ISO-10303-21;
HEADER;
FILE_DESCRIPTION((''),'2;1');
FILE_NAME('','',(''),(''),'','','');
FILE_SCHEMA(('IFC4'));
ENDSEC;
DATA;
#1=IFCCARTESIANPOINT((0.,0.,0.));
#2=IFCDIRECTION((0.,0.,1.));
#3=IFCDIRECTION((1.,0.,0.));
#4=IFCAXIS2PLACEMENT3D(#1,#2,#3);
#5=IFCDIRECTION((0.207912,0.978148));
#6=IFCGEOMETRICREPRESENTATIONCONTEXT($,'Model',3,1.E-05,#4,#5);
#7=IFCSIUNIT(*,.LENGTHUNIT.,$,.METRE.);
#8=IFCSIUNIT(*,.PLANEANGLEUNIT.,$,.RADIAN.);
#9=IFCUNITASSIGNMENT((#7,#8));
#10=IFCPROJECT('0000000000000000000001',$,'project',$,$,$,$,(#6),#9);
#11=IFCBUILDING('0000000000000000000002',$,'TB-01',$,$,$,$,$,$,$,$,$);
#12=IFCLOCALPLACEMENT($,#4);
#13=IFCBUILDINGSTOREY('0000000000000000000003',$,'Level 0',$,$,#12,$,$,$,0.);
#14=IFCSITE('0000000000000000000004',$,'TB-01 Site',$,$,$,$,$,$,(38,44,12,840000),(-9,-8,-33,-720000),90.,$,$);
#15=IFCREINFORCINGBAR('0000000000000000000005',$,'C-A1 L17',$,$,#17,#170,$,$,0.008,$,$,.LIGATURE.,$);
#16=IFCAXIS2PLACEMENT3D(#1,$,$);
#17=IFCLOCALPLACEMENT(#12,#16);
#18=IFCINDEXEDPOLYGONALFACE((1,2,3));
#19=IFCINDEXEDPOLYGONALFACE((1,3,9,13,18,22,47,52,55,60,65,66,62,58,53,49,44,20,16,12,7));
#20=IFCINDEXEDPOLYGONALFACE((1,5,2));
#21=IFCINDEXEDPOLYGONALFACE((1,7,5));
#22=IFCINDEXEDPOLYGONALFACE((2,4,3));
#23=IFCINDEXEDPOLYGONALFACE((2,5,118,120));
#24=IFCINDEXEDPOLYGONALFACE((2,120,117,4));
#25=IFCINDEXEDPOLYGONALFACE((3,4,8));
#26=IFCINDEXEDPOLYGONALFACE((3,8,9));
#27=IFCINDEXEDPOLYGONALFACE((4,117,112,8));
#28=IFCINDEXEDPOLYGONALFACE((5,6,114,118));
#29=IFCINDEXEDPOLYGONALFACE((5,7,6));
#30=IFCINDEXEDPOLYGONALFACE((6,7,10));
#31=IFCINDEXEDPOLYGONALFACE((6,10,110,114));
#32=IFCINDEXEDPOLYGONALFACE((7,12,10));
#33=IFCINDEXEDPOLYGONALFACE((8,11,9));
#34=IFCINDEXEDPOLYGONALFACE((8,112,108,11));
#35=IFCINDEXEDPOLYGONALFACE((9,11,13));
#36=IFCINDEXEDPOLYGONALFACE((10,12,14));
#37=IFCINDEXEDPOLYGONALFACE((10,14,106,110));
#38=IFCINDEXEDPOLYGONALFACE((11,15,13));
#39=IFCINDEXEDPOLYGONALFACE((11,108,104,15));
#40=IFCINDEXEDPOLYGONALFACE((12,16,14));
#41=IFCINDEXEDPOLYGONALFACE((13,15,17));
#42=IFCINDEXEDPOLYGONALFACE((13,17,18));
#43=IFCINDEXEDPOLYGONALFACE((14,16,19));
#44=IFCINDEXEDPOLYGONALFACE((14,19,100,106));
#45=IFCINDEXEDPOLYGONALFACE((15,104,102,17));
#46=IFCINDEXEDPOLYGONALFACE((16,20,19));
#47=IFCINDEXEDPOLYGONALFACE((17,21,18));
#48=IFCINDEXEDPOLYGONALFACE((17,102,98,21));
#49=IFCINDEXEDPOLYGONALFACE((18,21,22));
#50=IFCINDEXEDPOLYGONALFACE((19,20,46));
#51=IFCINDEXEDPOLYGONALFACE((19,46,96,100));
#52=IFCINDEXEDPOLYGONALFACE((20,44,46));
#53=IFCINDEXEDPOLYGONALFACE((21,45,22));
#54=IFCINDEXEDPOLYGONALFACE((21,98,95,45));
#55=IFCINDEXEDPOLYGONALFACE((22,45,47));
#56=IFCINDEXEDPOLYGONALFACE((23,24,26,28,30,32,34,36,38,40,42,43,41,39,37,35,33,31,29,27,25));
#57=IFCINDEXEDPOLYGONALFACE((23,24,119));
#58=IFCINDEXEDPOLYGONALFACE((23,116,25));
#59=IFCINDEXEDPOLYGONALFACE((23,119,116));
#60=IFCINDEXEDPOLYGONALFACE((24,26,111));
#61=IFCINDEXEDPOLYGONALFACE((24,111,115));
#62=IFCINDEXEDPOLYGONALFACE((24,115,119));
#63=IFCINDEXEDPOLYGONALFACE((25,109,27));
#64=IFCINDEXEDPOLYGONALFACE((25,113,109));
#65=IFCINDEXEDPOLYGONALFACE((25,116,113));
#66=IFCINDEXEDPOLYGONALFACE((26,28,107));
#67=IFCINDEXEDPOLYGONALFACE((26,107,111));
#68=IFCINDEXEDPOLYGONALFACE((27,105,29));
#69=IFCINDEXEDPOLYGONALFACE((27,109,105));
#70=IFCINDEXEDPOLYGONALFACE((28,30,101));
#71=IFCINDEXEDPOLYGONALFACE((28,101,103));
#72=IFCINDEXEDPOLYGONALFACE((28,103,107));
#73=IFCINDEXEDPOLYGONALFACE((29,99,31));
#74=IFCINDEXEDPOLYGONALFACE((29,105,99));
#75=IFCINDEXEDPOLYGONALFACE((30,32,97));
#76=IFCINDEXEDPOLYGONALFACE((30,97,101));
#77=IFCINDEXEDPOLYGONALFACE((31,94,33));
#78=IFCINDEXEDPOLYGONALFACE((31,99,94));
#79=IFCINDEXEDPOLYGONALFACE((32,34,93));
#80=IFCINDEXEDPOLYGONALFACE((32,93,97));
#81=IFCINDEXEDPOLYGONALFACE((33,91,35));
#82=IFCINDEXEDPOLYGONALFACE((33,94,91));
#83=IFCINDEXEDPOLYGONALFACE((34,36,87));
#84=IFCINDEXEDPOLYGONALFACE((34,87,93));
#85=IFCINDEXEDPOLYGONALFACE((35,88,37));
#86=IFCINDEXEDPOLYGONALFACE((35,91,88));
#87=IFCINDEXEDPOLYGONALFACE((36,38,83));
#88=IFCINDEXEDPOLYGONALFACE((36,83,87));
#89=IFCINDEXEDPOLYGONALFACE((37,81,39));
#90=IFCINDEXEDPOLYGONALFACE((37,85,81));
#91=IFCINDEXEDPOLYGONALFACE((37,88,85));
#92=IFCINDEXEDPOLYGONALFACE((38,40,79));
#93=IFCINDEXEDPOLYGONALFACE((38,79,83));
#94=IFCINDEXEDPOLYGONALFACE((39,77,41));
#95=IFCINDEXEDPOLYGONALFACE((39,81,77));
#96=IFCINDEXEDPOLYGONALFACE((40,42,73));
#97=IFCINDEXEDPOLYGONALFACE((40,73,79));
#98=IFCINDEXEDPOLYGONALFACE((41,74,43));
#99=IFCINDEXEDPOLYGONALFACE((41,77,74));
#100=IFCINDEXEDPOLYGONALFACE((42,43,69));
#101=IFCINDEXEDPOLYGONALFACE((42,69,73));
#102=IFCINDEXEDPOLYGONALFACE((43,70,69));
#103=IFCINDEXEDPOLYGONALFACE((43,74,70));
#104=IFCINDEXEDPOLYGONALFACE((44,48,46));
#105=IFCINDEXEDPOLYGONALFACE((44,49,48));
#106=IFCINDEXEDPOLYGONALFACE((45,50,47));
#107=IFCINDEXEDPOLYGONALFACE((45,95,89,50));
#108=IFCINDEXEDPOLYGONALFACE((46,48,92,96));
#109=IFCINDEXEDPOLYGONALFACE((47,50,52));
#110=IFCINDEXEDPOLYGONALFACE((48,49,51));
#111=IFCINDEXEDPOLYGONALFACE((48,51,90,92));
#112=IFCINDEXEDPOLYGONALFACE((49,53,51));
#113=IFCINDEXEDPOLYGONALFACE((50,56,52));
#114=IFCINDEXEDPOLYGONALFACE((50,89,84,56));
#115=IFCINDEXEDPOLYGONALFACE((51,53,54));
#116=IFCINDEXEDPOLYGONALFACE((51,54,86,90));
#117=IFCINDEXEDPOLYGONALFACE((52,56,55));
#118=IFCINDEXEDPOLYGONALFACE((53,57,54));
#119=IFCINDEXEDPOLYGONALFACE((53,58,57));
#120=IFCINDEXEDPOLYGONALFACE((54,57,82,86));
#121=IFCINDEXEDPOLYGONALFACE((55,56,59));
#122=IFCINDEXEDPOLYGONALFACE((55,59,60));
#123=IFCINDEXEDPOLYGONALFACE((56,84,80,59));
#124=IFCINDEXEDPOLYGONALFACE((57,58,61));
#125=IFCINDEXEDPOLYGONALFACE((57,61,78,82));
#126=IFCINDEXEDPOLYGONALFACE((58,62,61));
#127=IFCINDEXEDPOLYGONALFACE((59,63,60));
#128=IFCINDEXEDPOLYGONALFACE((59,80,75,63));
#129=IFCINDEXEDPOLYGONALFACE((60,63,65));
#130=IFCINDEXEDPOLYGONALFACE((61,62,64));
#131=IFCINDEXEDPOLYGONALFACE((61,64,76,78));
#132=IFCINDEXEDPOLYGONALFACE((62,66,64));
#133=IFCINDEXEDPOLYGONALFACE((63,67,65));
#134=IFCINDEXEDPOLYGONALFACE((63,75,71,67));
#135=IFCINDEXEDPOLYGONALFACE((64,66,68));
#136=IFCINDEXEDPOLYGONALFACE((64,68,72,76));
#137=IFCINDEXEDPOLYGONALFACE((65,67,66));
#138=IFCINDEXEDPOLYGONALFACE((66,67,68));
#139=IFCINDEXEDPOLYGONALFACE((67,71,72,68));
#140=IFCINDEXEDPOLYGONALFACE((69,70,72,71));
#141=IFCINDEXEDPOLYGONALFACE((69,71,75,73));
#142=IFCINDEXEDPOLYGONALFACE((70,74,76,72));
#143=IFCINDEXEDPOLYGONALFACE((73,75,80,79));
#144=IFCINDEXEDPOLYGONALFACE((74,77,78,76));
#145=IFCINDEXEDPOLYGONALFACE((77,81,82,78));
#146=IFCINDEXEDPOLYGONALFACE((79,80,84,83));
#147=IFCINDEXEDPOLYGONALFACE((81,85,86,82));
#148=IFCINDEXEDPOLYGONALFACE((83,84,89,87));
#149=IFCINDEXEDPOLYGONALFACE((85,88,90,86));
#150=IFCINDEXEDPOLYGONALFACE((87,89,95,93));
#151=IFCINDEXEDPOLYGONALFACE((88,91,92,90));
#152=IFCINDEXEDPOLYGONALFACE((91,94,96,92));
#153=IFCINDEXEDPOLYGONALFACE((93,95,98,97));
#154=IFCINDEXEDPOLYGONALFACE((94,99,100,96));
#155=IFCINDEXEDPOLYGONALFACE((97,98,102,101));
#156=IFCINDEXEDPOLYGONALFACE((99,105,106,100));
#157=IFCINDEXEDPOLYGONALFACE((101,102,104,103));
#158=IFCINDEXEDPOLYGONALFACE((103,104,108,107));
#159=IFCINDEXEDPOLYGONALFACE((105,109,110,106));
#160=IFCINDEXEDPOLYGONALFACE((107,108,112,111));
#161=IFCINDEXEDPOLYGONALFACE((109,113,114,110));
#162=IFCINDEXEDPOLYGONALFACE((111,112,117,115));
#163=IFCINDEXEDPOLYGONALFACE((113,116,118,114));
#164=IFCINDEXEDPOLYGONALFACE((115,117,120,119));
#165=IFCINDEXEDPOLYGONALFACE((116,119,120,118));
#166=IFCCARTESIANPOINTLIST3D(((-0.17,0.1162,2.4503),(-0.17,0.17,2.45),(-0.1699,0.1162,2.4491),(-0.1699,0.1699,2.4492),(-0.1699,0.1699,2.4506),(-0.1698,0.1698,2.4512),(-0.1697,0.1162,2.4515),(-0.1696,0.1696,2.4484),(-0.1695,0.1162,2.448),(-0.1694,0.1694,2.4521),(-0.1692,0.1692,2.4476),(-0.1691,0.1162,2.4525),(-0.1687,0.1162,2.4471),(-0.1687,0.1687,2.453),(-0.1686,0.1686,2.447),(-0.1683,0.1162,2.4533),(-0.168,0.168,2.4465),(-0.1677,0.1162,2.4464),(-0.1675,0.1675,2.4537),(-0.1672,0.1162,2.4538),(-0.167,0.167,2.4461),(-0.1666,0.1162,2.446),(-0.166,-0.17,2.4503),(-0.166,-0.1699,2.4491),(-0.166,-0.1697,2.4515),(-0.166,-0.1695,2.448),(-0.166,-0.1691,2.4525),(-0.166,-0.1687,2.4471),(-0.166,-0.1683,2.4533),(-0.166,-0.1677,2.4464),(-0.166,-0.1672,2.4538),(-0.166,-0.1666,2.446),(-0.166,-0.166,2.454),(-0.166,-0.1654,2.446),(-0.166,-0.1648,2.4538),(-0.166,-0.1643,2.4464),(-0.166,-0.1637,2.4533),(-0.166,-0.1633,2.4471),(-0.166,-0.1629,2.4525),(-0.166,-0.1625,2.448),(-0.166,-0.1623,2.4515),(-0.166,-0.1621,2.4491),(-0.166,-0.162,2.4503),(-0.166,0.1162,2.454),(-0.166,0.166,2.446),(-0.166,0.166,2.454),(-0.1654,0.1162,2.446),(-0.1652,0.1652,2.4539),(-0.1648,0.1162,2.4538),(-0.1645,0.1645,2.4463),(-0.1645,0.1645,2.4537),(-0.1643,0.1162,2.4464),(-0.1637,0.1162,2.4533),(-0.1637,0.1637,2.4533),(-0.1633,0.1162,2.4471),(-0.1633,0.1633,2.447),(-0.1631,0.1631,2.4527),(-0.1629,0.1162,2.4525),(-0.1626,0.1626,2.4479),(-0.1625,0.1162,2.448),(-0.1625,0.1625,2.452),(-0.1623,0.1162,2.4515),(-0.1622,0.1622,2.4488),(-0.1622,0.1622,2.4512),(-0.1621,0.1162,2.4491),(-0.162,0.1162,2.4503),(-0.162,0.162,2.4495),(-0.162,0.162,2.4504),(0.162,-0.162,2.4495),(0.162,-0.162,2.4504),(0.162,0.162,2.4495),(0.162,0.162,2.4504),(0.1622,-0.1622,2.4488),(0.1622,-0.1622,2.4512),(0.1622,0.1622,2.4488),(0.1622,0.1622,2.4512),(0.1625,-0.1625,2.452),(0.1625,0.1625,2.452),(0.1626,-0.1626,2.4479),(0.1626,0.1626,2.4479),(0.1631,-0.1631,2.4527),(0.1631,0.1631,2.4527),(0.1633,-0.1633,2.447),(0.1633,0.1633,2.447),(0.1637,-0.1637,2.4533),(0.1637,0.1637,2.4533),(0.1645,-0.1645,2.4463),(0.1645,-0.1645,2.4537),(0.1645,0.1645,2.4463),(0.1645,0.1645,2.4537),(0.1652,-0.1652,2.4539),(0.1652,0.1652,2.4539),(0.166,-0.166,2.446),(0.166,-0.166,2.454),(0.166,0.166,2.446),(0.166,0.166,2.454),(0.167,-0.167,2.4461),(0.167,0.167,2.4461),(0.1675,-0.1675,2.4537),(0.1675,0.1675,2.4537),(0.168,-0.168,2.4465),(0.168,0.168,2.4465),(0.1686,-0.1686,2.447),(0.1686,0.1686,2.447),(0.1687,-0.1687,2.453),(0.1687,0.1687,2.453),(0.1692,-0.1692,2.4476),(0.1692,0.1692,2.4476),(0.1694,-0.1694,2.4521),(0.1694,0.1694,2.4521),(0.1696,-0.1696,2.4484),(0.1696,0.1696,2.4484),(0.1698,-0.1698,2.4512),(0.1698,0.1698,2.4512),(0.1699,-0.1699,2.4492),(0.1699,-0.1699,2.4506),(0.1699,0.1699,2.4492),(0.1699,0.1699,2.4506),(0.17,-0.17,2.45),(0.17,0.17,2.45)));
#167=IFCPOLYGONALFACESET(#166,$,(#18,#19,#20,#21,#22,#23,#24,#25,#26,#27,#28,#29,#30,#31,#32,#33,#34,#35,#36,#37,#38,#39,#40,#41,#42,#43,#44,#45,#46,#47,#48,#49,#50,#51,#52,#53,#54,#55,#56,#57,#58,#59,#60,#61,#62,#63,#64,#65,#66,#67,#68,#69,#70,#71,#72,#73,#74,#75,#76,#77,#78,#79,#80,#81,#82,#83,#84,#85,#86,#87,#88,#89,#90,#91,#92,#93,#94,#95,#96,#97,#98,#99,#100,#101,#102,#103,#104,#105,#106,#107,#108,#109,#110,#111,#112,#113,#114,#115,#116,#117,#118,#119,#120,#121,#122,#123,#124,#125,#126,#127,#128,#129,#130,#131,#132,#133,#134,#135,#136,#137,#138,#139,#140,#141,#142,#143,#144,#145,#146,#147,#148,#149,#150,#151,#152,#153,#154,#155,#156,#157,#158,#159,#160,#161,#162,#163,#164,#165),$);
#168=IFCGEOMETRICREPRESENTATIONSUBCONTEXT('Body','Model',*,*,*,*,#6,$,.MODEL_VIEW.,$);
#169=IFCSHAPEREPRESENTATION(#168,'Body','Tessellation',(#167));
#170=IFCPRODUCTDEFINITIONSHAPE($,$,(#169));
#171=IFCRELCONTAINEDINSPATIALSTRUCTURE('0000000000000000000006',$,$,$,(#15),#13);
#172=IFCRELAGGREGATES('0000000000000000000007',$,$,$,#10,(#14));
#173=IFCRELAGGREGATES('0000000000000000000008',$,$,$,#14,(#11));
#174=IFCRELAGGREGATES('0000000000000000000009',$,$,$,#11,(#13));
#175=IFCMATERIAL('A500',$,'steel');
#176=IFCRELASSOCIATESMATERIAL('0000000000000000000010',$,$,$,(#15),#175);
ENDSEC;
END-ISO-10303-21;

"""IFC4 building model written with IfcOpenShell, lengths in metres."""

from ifc_helpers import new_model, entity, si_unit, direction, origin_with_axes, place, context, subcontext, project, spatial, material, element, save


model = new_model("IFC4")

# Units and contexts
model_context = context("Model", 3, precision=1e-05, world=origin_with_axes(), true_north=direction((0.207912, 0.978148)))
body_context = subcontext(model_context, "Body", "Model", "MODEL_VIEW")
ifc_project = project(units=[si_unit("LENGTHUNIT", "METRE"), si_unit("PLANEANGLEUNIT", "RADIAN")], contexts=[model_context])

# Site, building, storey
site = spatial("IfcSite", under=ifc_project, Name="TB-01 Site", RefLatitude=(38, 44, 12, 840000), RefLongitude=(-9, -8, -33, -720000), RefElevation=90.0)
building = spatial("IfcBuilding", under=site, Name="TB-01")
storey_placement = place(None, origin_with_axes())
storey = spatial("IfcBuildingStorey", under=building, at=storey_placement, Name="Level 0", Elevation=0.0)

# Reinforcing bar
ifc_material_1 = material(Name="A500", Category="steel")
reinforcing_bar_1_placement = place(storey_placement, origin_with_axes())
element("IfcReinforcingBar", 1, at=reinforcing_bar_1_placement, inside=storey, material=ifc_material_1, Name="C-A1 L17", NominalDiameter=0.008, PredefinedType="LIGATURE", context=body_context, shape_type="AdvancedSweptSolid", body=[
    entity("IfcSweptDiskSolid", entity("IfcPolyline", [entity("IfcCartesianPoint", [-0.166, -0.166, 2.45]), entity("IfcCartesianPoint", [0.166, -0.166, 2.45]), entity("IfcCartesianPoint", [0.166, 0.166, 2.45]), entity("IfcCartesianPoint", [-0.166, 0.166, 2.45]), entity("IfcCartesianPoint", [-0.166, 0.1162, 2.45])]), 0.004),
])

save(model, "model.ifc")
